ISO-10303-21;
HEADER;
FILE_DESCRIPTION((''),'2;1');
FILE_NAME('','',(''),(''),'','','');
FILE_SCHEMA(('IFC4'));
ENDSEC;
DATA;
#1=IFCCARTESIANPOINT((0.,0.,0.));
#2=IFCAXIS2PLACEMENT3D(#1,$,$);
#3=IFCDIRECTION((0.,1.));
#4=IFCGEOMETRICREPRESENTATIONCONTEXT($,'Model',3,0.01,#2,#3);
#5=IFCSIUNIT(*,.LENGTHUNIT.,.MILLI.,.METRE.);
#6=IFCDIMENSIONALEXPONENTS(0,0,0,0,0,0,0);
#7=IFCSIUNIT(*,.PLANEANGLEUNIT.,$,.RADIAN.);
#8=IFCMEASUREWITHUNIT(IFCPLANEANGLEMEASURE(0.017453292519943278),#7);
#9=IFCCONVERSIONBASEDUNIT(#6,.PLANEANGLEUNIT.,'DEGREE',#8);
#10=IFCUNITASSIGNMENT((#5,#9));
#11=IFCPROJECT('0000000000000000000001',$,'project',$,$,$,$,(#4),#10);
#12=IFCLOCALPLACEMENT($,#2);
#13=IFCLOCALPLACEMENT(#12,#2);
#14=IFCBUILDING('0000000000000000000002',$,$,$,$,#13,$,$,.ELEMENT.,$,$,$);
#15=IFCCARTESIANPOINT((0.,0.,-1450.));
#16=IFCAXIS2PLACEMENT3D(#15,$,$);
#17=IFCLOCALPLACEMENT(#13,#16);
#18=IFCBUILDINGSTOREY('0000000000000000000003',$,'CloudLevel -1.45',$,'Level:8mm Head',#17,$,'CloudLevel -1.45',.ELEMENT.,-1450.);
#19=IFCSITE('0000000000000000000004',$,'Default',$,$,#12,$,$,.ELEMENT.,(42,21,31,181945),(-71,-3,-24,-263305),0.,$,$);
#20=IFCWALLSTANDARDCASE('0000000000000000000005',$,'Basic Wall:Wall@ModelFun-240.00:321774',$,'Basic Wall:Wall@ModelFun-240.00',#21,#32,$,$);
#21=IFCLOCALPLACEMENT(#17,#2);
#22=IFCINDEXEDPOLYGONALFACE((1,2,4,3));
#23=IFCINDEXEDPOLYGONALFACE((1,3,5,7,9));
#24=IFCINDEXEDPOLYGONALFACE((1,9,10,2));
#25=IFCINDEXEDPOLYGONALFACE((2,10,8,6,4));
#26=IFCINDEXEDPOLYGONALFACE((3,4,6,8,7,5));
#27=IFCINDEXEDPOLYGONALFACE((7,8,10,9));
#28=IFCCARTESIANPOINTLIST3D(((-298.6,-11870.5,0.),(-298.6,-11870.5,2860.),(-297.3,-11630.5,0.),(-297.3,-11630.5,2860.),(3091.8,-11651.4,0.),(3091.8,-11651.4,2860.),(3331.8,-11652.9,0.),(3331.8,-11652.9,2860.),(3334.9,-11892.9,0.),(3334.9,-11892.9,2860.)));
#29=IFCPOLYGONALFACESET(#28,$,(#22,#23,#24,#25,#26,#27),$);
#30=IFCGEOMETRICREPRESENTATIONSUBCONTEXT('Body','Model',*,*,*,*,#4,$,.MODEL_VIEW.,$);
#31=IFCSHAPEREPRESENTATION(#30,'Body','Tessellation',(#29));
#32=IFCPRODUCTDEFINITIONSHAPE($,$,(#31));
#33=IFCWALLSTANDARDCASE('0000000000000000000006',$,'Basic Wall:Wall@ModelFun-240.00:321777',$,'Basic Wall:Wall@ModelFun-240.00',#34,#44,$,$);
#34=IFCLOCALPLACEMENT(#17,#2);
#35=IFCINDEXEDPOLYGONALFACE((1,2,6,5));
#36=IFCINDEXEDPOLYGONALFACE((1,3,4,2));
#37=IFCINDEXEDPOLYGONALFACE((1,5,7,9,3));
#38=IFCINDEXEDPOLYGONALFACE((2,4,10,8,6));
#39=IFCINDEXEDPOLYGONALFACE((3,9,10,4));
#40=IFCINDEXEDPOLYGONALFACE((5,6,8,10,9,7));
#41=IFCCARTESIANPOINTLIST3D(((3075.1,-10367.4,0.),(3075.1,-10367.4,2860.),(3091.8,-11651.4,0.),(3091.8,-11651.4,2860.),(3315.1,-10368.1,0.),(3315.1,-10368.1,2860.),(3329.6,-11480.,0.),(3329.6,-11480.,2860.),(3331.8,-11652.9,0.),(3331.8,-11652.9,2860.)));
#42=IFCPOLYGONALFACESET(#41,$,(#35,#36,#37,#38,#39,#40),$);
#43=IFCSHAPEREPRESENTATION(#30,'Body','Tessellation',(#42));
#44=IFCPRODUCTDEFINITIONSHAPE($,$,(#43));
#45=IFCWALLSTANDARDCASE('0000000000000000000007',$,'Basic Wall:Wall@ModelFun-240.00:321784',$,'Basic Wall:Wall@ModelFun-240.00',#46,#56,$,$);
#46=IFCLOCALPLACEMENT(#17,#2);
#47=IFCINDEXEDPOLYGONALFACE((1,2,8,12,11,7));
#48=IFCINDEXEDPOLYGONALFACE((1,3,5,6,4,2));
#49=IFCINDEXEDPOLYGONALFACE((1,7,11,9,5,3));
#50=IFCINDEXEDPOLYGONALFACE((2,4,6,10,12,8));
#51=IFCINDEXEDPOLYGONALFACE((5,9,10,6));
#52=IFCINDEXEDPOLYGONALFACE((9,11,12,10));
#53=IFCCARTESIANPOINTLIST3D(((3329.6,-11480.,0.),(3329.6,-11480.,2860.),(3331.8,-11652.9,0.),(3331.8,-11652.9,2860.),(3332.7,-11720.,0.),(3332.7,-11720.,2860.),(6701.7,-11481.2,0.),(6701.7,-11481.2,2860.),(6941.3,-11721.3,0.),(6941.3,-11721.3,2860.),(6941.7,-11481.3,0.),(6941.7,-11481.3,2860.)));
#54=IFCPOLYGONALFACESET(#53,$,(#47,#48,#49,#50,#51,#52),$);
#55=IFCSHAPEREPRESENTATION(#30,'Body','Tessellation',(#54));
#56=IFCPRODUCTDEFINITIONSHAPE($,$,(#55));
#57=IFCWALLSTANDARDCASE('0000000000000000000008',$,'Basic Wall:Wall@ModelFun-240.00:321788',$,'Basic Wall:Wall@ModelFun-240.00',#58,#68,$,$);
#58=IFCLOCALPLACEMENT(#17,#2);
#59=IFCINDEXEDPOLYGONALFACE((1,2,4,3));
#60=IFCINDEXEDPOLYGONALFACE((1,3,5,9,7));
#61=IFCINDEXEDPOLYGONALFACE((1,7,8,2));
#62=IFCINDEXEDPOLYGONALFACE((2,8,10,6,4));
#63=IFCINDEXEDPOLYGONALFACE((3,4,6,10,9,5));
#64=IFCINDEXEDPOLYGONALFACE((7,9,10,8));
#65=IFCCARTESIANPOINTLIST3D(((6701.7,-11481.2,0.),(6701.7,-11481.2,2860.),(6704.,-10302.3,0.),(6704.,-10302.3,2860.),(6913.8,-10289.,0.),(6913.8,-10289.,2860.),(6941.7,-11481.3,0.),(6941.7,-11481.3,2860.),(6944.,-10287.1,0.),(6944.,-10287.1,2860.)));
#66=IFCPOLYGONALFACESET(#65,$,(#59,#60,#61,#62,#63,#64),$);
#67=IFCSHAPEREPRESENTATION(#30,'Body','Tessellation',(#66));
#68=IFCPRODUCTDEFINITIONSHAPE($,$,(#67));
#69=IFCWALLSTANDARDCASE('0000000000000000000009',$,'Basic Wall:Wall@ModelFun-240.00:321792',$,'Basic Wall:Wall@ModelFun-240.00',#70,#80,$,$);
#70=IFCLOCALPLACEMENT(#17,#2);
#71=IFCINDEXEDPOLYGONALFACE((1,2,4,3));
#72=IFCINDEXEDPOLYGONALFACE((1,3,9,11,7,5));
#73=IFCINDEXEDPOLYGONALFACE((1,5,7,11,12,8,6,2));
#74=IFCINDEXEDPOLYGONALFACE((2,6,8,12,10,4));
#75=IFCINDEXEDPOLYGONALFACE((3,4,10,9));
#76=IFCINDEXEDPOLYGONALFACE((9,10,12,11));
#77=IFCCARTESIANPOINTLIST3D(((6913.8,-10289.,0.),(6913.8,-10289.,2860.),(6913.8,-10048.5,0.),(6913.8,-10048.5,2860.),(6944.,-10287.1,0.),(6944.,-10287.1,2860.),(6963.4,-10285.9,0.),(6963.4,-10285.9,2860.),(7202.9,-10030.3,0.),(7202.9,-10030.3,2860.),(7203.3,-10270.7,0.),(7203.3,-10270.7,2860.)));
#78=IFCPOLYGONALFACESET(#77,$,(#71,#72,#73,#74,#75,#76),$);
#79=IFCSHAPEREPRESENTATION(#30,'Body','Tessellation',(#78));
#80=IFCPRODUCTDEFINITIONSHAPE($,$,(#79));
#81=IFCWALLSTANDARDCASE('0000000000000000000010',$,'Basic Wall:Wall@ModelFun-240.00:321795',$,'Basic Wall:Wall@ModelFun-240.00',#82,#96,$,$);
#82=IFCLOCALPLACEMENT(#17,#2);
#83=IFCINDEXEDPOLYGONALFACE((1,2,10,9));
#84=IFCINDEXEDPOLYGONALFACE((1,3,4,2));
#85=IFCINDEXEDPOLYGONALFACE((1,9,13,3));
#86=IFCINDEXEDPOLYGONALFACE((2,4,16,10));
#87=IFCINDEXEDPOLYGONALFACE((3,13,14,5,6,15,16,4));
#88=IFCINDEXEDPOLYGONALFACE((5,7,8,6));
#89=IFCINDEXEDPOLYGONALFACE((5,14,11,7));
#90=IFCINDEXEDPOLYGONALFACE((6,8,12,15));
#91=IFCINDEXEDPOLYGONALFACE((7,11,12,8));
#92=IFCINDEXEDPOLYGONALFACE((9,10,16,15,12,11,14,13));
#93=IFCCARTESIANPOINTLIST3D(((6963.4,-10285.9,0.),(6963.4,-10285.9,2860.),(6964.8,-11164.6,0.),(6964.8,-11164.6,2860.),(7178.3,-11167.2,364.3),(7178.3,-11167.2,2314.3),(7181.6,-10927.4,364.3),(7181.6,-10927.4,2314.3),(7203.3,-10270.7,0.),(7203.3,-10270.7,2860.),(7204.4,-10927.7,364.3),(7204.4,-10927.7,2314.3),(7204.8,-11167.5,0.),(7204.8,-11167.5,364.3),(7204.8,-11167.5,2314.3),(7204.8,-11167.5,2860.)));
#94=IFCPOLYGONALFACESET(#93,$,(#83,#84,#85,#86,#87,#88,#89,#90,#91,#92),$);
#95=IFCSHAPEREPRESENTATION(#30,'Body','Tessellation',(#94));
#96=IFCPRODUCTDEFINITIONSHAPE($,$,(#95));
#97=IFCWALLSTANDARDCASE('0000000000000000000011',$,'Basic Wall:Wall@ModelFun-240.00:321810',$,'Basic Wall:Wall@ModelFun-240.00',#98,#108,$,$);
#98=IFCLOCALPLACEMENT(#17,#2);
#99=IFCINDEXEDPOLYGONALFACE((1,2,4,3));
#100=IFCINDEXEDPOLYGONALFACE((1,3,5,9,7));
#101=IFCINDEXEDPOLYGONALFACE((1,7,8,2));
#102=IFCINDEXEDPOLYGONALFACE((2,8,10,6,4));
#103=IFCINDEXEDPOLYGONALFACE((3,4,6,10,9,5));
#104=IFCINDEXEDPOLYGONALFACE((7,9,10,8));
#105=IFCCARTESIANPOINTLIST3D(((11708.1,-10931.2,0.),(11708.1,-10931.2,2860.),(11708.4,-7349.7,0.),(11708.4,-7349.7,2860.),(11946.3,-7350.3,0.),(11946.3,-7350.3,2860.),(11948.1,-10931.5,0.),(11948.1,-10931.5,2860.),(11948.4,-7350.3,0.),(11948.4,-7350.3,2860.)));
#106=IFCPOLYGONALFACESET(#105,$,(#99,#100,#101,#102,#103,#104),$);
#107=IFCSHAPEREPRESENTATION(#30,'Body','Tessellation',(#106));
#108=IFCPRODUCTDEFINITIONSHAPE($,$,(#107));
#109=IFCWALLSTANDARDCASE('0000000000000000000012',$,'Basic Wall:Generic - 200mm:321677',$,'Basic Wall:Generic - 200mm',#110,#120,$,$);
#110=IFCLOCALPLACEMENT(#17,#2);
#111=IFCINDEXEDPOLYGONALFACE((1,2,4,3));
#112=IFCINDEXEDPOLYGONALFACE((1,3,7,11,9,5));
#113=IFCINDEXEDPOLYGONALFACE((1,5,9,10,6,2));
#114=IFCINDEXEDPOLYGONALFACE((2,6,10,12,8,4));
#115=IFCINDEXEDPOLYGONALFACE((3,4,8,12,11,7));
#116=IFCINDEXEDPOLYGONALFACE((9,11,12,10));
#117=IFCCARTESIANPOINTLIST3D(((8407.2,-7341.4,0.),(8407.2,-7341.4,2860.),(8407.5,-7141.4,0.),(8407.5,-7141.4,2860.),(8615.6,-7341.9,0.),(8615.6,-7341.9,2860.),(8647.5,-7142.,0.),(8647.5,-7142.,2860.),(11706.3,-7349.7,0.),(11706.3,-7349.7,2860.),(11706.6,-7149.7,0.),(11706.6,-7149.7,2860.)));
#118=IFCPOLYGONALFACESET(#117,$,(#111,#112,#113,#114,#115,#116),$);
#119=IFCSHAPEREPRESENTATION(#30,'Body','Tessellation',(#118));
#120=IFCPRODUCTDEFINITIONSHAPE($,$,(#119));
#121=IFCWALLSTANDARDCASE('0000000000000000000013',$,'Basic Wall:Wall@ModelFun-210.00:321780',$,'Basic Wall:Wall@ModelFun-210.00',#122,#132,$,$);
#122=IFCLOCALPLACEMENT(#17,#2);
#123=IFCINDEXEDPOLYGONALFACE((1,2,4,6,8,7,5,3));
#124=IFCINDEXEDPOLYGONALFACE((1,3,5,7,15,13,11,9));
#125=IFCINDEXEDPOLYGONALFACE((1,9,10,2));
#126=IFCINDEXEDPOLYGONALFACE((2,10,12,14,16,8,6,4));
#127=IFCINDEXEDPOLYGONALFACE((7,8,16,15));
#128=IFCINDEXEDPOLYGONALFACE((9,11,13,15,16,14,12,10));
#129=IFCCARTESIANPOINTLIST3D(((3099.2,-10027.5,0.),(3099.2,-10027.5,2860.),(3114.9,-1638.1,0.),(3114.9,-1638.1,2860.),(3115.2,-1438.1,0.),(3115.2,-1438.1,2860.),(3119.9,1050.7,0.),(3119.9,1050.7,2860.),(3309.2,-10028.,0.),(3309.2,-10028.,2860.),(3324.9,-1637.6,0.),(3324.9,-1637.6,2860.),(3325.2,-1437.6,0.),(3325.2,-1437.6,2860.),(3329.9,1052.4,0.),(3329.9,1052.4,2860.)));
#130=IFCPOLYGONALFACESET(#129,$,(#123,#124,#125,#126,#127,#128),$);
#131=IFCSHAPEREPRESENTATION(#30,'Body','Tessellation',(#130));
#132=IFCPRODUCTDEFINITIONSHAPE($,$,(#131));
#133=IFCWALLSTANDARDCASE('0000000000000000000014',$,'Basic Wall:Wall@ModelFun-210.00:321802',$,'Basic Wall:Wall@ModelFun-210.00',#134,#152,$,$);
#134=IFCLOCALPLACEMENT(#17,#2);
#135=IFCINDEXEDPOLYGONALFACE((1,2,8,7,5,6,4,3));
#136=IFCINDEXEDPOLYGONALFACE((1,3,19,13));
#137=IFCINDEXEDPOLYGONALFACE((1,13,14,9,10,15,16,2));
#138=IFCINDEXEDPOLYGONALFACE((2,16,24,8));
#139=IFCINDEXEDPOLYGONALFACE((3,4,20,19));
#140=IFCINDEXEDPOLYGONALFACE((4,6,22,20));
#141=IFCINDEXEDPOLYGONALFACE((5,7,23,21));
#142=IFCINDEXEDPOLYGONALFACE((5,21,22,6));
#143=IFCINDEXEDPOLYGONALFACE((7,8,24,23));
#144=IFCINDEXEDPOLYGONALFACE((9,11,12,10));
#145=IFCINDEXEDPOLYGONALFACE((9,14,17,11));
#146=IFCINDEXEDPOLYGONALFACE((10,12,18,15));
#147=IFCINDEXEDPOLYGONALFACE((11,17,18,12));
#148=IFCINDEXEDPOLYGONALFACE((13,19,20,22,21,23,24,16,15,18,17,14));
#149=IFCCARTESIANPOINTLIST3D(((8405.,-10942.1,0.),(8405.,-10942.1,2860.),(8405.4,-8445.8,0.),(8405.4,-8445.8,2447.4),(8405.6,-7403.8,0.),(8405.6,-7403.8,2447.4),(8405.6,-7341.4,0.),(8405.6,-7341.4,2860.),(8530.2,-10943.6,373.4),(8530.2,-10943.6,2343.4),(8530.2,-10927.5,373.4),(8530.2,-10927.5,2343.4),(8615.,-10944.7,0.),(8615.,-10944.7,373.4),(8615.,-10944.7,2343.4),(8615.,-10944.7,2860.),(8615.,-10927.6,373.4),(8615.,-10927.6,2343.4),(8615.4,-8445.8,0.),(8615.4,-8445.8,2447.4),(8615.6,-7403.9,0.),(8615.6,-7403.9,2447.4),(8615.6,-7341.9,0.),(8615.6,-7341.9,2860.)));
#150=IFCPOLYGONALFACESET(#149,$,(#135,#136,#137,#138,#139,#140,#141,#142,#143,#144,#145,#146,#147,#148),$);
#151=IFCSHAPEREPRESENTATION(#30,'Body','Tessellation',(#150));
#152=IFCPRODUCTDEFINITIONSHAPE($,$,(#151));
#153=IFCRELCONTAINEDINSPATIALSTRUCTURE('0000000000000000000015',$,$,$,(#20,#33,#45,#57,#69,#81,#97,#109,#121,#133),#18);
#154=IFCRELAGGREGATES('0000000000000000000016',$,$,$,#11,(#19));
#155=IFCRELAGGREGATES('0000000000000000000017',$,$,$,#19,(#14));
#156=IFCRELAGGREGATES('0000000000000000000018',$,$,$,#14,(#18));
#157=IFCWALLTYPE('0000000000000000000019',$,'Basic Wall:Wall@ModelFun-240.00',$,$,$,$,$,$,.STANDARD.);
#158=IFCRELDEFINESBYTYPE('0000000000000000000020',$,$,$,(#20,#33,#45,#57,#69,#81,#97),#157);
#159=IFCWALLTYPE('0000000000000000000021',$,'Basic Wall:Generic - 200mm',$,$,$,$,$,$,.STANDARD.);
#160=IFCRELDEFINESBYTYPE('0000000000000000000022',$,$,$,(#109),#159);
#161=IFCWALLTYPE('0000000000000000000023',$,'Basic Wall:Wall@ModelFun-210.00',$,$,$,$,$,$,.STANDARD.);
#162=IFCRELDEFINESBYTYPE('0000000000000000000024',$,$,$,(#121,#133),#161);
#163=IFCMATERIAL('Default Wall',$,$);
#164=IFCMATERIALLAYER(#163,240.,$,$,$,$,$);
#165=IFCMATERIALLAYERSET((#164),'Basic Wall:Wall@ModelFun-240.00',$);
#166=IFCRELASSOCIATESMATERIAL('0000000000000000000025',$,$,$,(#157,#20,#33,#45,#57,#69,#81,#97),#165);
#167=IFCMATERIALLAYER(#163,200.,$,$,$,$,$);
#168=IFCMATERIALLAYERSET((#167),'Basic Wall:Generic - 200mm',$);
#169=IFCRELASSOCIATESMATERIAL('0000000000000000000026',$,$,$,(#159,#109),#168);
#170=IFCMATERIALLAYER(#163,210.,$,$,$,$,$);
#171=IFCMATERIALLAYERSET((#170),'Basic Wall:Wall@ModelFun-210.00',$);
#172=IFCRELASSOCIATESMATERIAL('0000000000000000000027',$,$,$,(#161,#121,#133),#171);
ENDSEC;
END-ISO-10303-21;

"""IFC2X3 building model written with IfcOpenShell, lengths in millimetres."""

from ifc_helpers import new_model, entity, si_unit, converted_unit, direction, frame, frame_2d, origin, place, context, subcontext, project, spatial, polyline, rectangle, outline, extrude, material, layer, layer_set, layer_usage, type_object, element, save


model = new_model("IFC2X3")

# Units and contexts
model_context = context("Model", 3, precision=0.01, world=origin(), true_north=direction((0.0, 1.0)))
body_context = subcontext(model_context, "Body", "Model", "MODEL_VIEW")
ifc_project = project(units=[si_unit("LENGTHUNIT", "METRE", prefix="MILLI"), converted_unit("PLANEANGLEUNIT", "DEGREE", entity("IfcPlaneAngleMeasure", 0.017453292519943278), si_unit("PLANEANGLEUNIT", "RADIAN"), dimensions=[0, 0, 0, 0, 0, 0, 0])], contexts=[model_context])

# Site, building, storey
site_placement = place(None, origin())
site = spatial("IfcSite", under=ifc_project, at=site_placement, Name="Default", CompositionType="ELEMENT", RefLatitude=(42, 21, 31, 181945), RefLongitude=(-71, -3, -24, -263305), RefElevation=0.0)
building_placement = place(site_placement, origin())
building = spatial("IfcBuilding", under=site, at=building_placement, CompositionType="ELEMENT")
storey_placement = place(building_placement, frame((0.0, 0.0, -1450.0)))
storey = spatial("IfcBuildingStorey", under=building, at=storey_placement, Name="CloudLevel -1.45", ObjectType="Level:8mm Head", LongName="CloudLevel -1.45", CompositionType="ELEMENT", Elevation=-1450.0)

# Walls
ifc_material_1 = material(Name="Default Wall")
ifc_layer_1 = layer(ifc_material_1, 240.0)
ifc_layer_set_1 = layer_set([ifc_layer_1], Name="Basic Wall:Wall@ModelFun-240.00")
ifc_layer_usage_1 = layer_usage(ifc_layer_set_1, "AXIS2", "NEGATIVE", 120.0)
wall_type_1 = type_object("IfcWallType", Name="Basic Wall:Wall@ModelFun-240.00", PredefinedType="STANDARD", material=ifc_layer_set_1)
wall_1_placement = place(storey_placement, frame((3335.6, -11772.9, 0.0), z_axis=(0.0, 0.0, 1.0), x_axis=(-0.999981, 0.006158, 0.0)))
element("IfcWallStandardCase", 1, at=wall_1_placement, inside=storey, type_object=wall_type_1, material=ifc_layer_usage_1, Name="Basic Wall:Wall@ModelFun-240.00:321774", ObjectType="Basic Wall:Wall@ModelFun-240.00", context=body_context, shape_type="SweptSolid", body=[
    extrude(outline(polyline([(3633.7, -120.0), (3633.5, 120.0), (0.0, 120.0), (4.6, -120.0), (244.6, -120.0), (3633.7, -120.0)])), origin(), (0.0, 0.0, 1.0), 2860.0),
])
wall_2_placement = place(storey_placement, frame((3211.8, -11654.4, 0.0), z_axis=(0.0, 0.0, 1.0), x_axis=(-0.012952, 0.999916, 0.0)))
element("IfcWallStandardCase", 2, at=wall_2_placement, inside=storey, type_object=wall_type_1, material=ifc_layer_usage_1, Name="Basic Wall:Wall@ModelFun-240.00:321777", ObjectType="Basic Wall:Wall@ModelFun-240.00", context=body_context, shape_type="SweptSolid", body=[
    extrude(outline(polyline([(1284.9, -120.0), (1288.7, 120.0), (4.6, 120.0), (0.0, -120.0), (172.9, -120.0), (1284.9, -120.0)])), origin(), (0.0, 0.0, 1.0), 2860.0),
])
wall_3_placement = place(storey_placement, frame((6941.7, -11601.3, 0.0), z_axis=(0.0, 0.0, 1.0), x_axis=(-1.0, 0.000347, 0.0)))
element("IfcWallStandardCase", 3, at=wall_3_placement, inside=storey, type_object=wall_type_1, material=ifc_layer_usage_1, Name="Basic Wall:Wall@ModelFun-240.00:321784", ObjectType="Basic Wall:Wall@ModelFun-240.00", context=body_context, shape_type="SweptSolid", body=[
    extrude(outline(polyline([(3612.2, -120.0), (3609.9, 52.8), (3609.0, 120.0), (0.4, 120.0), (0.0, -120.0), (240.0, -120.0), (3612.2, -120.0)])), origin(), (0.0, 0.0, 1.0), 2860.0),
])
wall_4_placement = place(storey_placement, frame((6824.0, -10286.9, 0.0), z_axis=(0.0, 0.0, 1.0), x_axis=(-0.001903, -0.999998, 0.0)))
element("IfcWallStandardCase", 4, at=wall_4_placement, inside=storey, type_object=wall_type_1, material=ifc_layer_usage_1, Name="Basic Wall:Wall@ModelFun-240.00:321788", ObjectType="Basic Wall:Wall@ModelFun-240.00", context=body_context, shape_type="SweptSolid", body=[
    extrude(outline(polyline([(1194.6, -120.0), (1194.2, 120.0), (0.0, 120.0), (2.0, 89.8), (15.6, -120.0), (1194.6, -120.0)])), origin(), (0.0, 0.0, 1.0), 2860.0),
])
wall_5_placement = place(storey_placement, frame((6906.2, -10169.3, 0.0), z_axis=(0.0, 0.0, 1.0), x_axis=(0.998007, 0.0631, 0.0)))
element("IfcWallStandardCase", 5, at=wall_5_placement, inside=storey, type_object=wall_type_1, material=ifc_layer_usage_1, Name="Basic Wall:Wall@ModelFun-240.00:321792", ObjectType="Basic Wall:Wall@ModelFun-240.00", context=body_context, shape_type="SweptSolid", body=[
    extrude(outline(polyline([(290.1, -120.0), (304.9, 120.0), (15.2, 120.0), (0.0, -120.0), (30.3, -120.0), (49.7, -120.0), (290.1, -120.0)])), origin(), (0.0, 0.0, 1.0), 2860.0),
])

# Wall, opening
wall_6_placement = place(storey_placement, frame((7083.3, -10270.9, 0.0), z_axis=(0.0, 0.0, 1.0), x_axis=(0.001683, -0.999999, 0.0)))
wall_6 = element("IfcWallStandardCase", 6, at=wall_6_placement, inside=storey, type_object=wall_type_1, material=ifc_layer_usage_1, Name="Basic Wall:Wall@ModelFun-240.00:321795", ObjectType="Basic Wall:Wall@ModelFun-240.00", context=body_context, shape_type="SweptSolid", body=[
    extrude(outline(polyline([(893.5, -120.0), (896.8, 120.0), (656.8, 120.0), (0.0, 120.0), (14.8, -120.0), (893.5, -120.0)])), origin(), (0.0, 0.0, 1.0), 2860.0),
])
opening_1_placement = place(wall_6_placement, frame((0.0, 0.0, 0.0), z_axis=(0.0, 0.0, 1.0), x_axis=(0.999999, -0.001683, 0.0)))
element("IfcOpeningElement", 7, at=opening_1_placement, cuts=wall_6, ObjectType="Opening", context=body_context, shape_type="SweptSolid", body=[
    extrude(rectangle(XDim=1950.0, YDim=240.0, at=frame_2d((0.0, 0.0), x_axis=(0.0, 1.0))), frame((776.5, 96.6, 1339.3), z_axis=(0.013838, 0.999904, 0.0), x_axis=(0.999904, -0.013838, 0.0)), (0.0, 0.0, 1.0), 1390.0),
])

# Walls
wall_7_placement = place(storey_placement, frame((11828.1, -10931.4, 0.0), z_axis=(0.0, 0.0, 1.0), x_axis=(0.000075, 1.0, 0.0)))
element("IfcWallStandardCase", 8, at=wall_7_placement, inside=storey, type_object=wall_type_1, material=ifc_layer_usage_1, Name="Basic Wall:Wall@ModelFun-240.00:321810", ObjectType="Basic Wall:Wall@ModelFun-240.00", context=body_context, shape_type="SweptSolid", body=[
    extrude(outline(polyline([(3581.1, -120.0), (3581.1, -117.9), (3581.7, 120.0), (0.3, 120.0), (0.0, -120.0), (3581.1, -120.0)])), origin(), (0.0, 0.0, 1.0), 2860.0),
])
ifc_layer_2 = layer(ifc_material_1, 200.0)
ifc_layer_set_2 = layer_set([ifc_layer_2], Name="Basic Wall:Generic - 200mm")
ifc_layer_usage_2 = layer_usage(ifc_layer_set_2, "AXIS2", "NEGATIVE", 100.0)
wall_type_2 = type_object("IfcWallType", Name="Basic Wall:Generic - 200mm", PredefinedType="STANDARD", material=ifc_layer_set_2)
wall_8_placement = place(storey_placement, frame((11706.5, -7249.7, 0.0), z_axis=(0.0, 0.0, 1.0), x_axis=(-0.999997, 0.002521, 0.0)))
element("IfcWallStandardCase", 9, at=wall_8_placement, inside=storey, type_object=wall_type_2, material=ifc_layer_usage_2, Name="Basic Wall:Generic - 200mm:321677", ObjectType="Basic Wall:Generic - 200mm", context=body_context, shape_type="SweptSolid", body=[
    extrude(outline(polyline([(3299.3, -100.0), (3299.0, 100.0), (3090.7, 100.0), (0.0, 100.0), (0.2, -100.0), (3059.3, -100.0), (3299.3, -100.0)])), origin(), (0.0, 0.0, 1.0), 2860.0),
])
ifc_layer_3 = layer(ifc_material_1, 210.0)
ifc_layer_set_3 = layer_set([ifc_layer_3], Name="Basic Wall:Wall@ModelFun-210.00")
ifc_layer_usage_3 = layer_usage(ifc_layer_set_3, "AXIS2", "NEGATIVE", 105.0)
wall_type_3 = type_object("IfcWallType", Name="Basic Wall:Wall@ModelFun-210.00", PredefinedType="STANDARD", material=ifc_layer_set_3)
wall_9_placement = place(storey_placement, frame((3204.2, -10027.8, 0.0), z_axis=(0.0, 0.0, 1.0), x_axis=(0.001862, 0.999998, 0.0)))
element("IfcWallStandardCase", 10, at=wall_9_placement, inside=storey, type_object=wall_type_3, material=ifc_layer_usage_3, Name="Basic Wall:Wall@ModelFun-210.00:321780", ObjectType="Basic Wall:Wall@ModelFun-210.00", context=body_context, shape_type="SweptSolid", body=[
    extrude(outline(polyline([(11080.4, -105.0), (11078.4, 105.0), (8589.6, 105.0), (8389.6, 105.0), (0.2, 105.0), (0.0, -105.0), (8390.5, -105.0), (8590.5, -105.0), (11080.4, -105.0)])), origin(), (0.0, 0.0, 1.0), 2860.0),
])

# Wall, openings
wall_10_placement = place(storey_placement, frame((8510.6, -7341.4, 0.0), z_axis=(0.0, 0.0, 1.0), x_axis=(-0.000175, -1.0, 0.0)))
wall_10 = element("IfcWallStandardCase", 11, at=wall_10_placement, inside=storey, type_object=wall_type_3, material=ifc_layer_usage_3, Name="Basic Wall:Wall@ModelFun-210.00:321802", ObjectType="Basic Wall:Wall@ModelFun-210.00", context=body_context, shape_type="SweptSolid", body=[
    extrude(outline(polyline([(0.0, -105.0), (1096.3, -105.0), (1206.3, -105.0), (3600.7, -105.0), (3603.2, 105.0), (3586.2, 105.0), (0.5, 105.0), (0.0, -103.4), (0.0, -105.0)])), origin(), (0.0, 0.0, 1.0), 2860.0),
])
opening_2_placement = place(wall_10_placement, frame((0.0, 0.0, 0.0), z_axis=(0.0, 0.0, 1.0), x_axis=(1.0, 0.000175, 0.0)))
element("IfcOpeningElement", 12, at=opening_2_placement, cuts=wall_10, ObjectType="Opening", context=body_context, shape_type="SweptSolid", body=[
    extrude(rectangle(XDim=1970.0, YDim=240.0, at=frame_2d((0.0, 0.0), x_axis=(0.0, 1.0))), frame((3706.1, 19.5, 1358.4), z_axis=(0.000975, 1.0, 0.0), x_axis=(-1.0, 0.000975, 0.0)), (0.0, 0.0, 1.0), 3070.0),
])
opening_3_placement = place(wall_10_placement, frame((62.4, -105.0, 0.0)))
element("IfcOpeningElement", 13, at=opening_3_placement, cuts=wall_10, ObjectType="Opening", context=body_context, shape_type="SweptSolid", body=[
    extrude(rectangle(XDim=1042.0, YDim=2447.4, at=frame_2d((1223.7, 521.0), x_axis=(0.0, 1.0))), frame((0.0, 0.0, 0.0), z_axis=(0.0, 1.0, 0.0), x_axis=(0.0, 0.0, 1.0)), (0.0, 0.0, 1.0), 210.0),
])

save(model, "model.ifc")
